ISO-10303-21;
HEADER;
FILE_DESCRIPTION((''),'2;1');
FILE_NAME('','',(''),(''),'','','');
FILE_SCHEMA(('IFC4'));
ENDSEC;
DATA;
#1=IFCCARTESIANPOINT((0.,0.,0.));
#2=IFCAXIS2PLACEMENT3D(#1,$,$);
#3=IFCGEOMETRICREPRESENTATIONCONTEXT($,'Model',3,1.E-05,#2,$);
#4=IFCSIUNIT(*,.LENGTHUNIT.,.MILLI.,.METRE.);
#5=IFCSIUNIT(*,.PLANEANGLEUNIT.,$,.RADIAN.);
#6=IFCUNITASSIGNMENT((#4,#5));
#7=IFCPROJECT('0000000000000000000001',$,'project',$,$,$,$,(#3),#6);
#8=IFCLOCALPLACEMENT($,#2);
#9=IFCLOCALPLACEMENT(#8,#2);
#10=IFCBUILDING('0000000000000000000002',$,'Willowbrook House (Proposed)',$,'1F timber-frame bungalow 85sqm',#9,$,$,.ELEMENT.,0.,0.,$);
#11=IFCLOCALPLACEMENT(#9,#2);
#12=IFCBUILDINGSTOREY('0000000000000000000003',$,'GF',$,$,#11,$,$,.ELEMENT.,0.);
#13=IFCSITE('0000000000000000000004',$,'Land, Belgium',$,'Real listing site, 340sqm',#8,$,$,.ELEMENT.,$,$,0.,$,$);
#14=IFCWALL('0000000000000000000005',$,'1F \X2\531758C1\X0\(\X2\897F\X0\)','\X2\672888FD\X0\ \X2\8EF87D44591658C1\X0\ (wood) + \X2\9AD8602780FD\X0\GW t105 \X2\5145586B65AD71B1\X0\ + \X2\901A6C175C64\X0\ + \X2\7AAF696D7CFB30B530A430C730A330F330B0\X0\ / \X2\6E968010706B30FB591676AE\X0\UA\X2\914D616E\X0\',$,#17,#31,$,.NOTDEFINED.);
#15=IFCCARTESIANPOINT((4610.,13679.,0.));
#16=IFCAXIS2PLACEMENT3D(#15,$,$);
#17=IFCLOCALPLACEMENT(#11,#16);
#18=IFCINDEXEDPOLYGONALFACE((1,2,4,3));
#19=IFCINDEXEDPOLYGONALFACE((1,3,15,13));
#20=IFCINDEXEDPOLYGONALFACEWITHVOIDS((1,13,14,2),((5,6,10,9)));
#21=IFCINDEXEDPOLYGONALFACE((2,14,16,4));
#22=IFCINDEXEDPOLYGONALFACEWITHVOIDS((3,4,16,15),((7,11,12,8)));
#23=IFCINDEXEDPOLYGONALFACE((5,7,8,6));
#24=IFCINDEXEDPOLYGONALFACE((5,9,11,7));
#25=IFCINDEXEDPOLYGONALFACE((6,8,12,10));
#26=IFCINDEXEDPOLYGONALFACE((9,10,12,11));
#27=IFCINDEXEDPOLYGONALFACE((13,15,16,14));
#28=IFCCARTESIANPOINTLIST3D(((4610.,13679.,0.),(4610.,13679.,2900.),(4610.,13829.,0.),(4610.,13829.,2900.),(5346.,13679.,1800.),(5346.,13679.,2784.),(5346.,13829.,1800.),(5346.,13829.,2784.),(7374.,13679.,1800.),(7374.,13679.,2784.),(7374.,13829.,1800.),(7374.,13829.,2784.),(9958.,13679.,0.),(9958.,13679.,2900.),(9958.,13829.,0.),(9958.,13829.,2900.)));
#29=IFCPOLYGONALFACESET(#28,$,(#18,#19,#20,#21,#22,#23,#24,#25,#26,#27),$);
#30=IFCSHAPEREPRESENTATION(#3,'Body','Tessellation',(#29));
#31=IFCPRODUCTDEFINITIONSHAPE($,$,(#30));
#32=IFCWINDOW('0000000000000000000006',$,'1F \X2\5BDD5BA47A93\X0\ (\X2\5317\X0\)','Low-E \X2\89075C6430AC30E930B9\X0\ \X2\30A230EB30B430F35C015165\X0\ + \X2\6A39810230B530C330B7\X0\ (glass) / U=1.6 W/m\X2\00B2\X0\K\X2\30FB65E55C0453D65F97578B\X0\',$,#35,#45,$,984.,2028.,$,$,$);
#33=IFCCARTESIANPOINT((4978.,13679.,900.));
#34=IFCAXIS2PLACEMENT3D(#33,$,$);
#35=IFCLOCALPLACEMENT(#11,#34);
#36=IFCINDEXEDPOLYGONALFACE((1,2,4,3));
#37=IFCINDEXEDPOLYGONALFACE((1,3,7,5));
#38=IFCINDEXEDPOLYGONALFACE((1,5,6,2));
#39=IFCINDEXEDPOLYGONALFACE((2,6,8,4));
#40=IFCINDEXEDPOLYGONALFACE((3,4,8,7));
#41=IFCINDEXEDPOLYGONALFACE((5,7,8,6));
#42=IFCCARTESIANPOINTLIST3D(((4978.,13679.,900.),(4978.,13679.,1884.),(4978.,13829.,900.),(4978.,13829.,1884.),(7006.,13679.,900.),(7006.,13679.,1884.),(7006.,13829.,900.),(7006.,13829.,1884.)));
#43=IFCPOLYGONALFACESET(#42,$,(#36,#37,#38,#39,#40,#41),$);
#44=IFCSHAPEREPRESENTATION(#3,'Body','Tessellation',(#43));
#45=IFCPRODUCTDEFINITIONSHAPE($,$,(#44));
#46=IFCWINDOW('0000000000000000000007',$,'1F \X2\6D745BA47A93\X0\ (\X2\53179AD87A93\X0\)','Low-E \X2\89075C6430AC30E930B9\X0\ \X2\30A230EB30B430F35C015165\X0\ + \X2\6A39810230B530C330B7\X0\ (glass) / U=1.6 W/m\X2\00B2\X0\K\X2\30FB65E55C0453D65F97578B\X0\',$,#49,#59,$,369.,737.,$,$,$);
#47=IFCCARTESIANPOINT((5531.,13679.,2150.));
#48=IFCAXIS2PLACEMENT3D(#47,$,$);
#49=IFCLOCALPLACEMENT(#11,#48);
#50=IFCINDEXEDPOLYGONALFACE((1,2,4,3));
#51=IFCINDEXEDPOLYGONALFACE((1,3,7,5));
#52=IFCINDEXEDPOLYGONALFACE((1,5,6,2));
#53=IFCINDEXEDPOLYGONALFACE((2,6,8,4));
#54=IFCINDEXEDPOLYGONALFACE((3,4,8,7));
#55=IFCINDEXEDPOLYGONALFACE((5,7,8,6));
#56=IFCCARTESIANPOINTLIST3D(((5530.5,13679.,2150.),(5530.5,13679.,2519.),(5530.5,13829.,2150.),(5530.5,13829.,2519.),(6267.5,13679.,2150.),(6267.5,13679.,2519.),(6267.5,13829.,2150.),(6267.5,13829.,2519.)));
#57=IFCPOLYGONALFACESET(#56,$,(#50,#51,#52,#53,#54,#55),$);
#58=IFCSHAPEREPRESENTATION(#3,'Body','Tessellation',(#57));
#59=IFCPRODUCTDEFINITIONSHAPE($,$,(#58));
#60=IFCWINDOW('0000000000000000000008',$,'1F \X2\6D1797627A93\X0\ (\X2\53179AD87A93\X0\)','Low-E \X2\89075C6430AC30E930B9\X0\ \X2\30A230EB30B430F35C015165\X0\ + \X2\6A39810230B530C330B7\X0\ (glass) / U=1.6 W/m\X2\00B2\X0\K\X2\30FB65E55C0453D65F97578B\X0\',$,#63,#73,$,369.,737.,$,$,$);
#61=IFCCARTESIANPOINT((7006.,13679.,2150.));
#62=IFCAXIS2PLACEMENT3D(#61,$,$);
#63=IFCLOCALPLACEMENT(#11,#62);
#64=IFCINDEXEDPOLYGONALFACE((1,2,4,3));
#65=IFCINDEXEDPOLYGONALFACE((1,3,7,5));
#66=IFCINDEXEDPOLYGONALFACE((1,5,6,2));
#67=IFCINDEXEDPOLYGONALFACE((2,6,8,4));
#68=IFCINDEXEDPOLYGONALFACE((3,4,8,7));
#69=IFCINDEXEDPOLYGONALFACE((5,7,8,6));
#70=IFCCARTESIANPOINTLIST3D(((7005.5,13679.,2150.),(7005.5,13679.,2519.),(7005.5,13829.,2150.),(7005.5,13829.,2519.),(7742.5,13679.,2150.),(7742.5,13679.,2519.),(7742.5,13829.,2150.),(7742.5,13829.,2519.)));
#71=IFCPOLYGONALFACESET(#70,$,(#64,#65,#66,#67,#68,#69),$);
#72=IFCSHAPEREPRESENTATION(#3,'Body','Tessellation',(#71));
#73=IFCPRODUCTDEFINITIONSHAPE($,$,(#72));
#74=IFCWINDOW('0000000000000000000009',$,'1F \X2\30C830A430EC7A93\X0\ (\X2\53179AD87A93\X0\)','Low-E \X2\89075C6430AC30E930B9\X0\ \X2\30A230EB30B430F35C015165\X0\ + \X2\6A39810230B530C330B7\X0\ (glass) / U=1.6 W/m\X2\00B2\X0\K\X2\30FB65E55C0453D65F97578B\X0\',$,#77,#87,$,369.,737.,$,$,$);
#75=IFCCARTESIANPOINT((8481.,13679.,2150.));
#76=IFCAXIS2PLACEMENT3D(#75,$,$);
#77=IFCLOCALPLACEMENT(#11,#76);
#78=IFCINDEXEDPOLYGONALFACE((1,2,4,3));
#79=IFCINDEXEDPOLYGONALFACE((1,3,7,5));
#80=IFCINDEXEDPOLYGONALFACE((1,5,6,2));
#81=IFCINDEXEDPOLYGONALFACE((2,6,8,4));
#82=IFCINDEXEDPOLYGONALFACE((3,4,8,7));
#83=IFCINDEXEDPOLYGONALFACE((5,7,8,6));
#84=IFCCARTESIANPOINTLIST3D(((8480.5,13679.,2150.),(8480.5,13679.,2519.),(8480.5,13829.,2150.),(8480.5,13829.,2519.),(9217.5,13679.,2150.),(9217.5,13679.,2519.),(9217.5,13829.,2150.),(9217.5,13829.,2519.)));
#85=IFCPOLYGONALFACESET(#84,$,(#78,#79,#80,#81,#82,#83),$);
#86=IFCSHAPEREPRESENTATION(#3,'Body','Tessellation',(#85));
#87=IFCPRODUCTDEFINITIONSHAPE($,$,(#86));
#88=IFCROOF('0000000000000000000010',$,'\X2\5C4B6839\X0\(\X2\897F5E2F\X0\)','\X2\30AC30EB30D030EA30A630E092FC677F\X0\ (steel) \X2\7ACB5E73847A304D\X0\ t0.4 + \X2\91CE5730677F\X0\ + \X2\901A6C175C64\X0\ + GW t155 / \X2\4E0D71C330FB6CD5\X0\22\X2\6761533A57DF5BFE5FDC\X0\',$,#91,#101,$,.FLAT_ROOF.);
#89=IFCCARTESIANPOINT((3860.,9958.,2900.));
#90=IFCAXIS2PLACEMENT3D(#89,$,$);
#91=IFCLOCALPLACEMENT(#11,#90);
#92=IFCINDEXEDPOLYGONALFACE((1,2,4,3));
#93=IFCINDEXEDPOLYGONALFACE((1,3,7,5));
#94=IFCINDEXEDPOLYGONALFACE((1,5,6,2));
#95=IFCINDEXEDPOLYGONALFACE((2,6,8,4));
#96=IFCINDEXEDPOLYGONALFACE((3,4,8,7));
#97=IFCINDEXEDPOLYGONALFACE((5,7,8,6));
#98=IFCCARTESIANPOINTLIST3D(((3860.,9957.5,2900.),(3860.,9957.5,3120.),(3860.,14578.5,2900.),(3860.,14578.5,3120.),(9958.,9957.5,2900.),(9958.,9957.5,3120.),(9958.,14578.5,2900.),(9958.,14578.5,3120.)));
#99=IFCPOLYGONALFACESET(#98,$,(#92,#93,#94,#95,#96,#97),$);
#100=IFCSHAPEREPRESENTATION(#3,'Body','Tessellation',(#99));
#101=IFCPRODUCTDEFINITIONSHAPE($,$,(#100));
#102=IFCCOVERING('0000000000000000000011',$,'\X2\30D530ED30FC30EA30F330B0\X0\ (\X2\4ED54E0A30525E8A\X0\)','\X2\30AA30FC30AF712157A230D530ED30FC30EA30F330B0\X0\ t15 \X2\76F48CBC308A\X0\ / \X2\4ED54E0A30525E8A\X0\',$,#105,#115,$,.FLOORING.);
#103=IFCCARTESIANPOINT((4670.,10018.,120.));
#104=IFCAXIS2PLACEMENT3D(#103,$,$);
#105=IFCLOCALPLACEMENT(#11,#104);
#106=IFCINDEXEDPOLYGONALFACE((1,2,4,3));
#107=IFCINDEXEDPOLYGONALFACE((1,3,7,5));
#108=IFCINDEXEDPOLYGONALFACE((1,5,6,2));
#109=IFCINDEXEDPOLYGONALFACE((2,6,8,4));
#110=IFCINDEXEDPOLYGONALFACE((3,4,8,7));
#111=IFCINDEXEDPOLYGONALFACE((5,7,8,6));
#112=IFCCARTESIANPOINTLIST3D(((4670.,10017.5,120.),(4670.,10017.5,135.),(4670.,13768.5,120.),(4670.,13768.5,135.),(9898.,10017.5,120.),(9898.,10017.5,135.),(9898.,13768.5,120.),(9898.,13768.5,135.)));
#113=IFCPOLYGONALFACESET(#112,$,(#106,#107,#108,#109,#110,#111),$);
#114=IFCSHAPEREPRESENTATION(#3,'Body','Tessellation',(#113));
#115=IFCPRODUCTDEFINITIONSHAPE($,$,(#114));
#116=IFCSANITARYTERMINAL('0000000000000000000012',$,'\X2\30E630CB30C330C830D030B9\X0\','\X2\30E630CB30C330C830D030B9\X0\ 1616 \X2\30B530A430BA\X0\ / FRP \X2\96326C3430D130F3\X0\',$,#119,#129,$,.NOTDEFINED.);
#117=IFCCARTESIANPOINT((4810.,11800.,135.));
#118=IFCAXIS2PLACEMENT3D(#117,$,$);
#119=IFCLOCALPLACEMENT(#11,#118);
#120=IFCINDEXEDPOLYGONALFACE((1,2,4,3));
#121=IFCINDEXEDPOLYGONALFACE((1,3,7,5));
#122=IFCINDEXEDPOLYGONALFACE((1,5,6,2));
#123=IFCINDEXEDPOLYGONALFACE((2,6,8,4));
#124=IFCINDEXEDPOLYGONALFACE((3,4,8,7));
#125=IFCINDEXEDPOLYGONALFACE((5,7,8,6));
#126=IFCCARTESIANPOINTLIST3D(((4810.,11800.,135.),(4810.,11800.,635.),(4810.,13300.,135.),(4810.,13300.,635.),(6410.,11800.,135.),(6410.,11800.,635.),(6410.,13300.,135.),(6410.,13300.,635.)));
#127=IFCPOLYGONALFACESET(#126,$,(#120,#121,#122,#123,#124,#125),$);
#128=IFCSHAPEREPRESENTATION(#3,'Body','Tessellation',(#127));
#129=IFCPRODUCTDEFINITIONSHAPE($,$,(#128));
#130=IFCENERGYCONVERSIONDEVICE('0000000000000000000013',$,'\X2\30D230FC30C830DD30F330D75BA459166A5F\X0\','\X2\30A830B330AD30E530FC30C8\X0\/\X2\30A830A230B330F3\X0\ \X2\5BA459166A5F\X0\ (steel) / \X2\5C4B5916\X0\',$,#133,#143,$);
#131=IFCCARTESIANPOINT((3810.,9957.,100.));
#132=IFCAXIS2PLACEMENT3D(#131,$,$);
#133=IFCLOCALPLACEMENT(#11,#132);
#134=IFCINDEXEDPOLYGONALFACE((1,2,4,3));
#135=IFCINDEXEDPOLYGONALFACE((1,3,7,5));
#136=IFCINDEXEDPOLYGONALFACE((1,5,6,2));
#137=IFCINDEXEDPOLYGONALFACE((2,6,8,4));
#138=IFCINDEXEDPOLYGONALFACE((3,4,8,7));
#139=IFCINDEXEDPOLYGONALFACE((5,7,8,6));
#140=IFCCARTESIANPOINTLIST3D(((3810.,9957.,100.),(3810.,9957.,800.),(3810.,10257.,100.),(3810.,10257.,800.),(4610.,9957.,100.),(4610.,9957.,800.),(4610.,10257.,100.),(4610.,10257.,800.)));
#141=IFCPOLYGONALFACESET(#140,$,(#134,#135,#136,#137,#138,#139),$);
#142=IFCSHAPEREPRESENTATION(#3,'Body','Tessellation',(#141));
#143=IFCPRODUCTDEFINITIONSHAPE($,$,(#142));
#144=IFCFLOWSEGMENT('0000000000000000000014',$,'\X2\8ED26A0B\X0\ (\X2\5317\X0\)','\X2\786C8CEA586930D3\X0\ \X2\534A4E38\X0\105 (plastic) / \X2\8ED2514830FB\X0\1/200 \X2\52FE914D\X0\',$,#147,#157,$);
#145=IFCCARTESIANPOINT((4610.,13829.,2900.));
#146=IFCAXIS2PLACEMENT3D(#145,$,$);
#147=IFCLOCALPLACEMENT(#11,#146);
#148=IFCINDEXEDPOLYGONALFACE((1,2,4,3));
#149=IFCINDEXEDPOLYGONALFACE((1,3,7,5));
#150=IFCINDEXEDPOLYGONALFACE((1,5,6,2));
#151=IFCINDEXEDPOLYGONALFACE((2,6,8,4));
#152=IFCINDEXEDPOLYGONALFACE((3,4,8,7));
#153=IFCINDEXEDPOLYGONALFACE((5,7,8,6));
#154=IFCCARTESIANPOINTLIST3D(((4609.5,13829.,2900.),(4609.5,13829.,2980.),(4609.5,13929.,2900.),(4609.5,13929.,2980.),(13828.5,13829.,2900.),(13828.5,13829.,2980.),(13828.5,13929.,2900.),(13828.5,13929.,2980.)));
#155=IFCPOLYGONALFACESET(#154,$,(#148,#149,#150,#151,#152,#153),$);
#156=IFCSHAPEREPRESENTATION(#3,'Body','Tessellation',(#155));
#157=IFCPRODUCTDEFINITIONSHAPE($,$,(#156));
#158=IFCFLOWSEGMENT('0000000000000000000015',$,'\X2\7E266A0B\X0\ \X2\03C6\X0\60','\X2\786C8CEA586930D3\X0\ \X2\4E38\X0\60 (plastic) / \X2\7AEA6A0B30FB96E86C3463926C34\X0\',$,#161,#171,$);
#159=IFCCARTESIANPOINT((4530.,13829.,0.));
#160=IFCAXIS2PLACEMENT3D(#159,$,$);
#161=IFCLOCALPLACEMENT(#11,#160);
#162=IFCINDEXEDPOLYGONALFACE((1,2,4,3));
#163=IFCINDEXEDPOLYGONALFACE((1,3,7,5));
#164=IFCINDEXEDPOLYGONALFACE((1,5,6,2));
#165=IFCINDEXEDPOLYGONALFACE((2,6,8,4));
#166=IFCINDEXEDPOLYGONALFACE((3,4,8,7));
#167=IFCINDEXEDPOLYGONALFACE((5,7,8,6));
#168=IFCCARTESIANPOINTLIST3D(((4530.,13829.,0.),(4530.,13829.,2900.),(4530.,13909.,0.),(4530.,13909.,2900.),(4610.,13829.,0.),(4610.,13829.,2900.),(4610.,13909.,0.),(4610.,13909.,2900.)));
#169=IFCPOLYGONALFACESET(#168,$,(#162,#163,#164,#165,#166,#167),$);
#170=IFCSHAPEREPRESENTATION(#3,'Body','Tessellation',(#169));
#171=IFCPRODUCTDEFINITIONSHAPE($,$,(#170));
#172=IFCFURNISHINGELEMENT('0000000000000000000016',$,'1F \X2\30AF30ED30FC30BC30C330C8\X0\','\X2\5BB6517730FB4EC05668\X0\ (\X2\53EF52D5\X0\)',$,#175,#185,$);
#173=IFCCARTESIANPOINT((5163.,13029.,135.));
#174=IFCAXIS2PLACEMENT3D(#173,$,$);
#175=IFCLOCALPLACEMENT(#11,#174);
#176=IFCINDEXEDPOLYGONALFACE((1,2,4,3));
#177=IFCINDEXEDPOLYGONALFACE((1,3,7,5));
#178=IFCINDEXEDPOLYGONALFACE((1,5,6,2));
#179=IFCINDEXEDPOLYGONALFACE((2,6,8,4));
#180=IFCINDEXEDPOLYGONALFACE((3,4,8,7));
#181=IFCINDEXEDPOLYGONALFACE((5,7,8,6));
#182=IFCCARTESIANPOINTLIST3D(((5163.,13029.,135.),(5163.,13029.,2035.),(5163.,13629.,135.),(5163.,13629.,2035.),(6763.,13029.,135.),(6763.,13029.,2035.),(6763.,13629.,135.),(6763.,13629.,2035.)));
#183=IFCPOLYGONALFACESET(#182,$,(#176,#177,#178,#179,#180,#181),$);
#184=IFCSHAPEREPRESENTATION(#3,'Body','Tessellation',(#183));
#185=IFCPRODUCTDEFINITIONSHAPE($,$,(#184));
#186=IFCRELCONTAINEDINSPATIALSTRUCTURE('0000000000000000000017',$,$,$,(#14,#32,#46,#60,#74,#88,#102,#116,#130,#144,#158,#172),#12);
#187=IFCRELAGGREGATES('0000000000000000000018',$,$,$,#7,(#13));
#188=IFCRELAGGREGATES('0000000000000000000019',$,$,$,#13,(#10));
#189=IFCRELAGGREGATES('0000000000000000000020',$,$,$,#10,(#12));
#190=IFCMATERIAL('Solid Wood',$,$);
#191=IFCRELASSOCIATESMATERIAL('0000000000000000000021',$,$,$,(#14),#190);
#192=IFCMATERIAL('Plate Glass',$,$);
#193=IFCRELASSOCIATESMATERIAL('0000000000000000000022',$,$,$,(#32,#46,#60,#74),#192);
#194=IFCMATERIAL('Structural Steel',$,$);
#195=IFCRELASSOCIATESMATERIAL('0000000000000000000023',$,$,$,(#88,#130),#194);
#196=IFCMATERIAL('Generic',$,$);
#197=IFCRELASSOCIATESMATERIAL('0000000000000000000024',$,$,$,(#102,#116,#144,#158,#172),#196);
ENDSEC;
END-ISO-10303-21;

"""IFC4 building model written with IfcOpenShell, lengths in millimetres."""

from ifc_helpers import new_model, si_unit, frame, frame_2d, origin, place, context, project, spatial, rectangle, extrude, material, element, fill, save


model = new_model("IFC4")

# Units and contexts
model_context = context("Model", 3, precision=1e-05, world=origin())
ifc_project = project(units=[si_unit("LENGTHUNIT", "METRE", prefix="MILLI"), si_unit("PLANEANGLEUNIT", "RADIAN")], contexts=[model_context])

# Site, building, storey
site_placement = place(None, origin())
site = spatial("IfcSite", under=ifc_project, at=site_placement, Name="Land, Belgium", ObjectType="Real listing site, 340sqm", CompositionType="ELEMENT", RefElevation=0.0)
building_placement = place(site_placement, origin())
building = spatial("IfcBuilding", under=site, at=building_placement, Name="Willowbrook House (Proposed)", ObjectType="1F timber-frame bungalow 85sqm", CompositionType="ELEMENT", ElevationOfRefHeight=0.0, ElevationOfTerrain=0.0)
storey_placement = place(building_placement, origin())
storey = spatial("IfcBuildingStorey", under=building, at=storey_placement, Name="GF", CompositionType="ELEMENT", Elevation=0.0)

# Shared definitions
ifc_material_1 = material(Name="Solid Wood")

# Wall, openings, windows
wall_1_placement = place(storey_placement, frame((4610.0, 13679.0, 0.0)))
wall_1 = element("IfcWall", 1, at=wall_1_placement, inside=storey, material=ifc_material_1, Name="1F 北壁(西)", Description="木製 軸組外壁 (wood) + 高性能GW t105 充填断熱 + 通気層 + 窯業系サイディング / 準耐火・外皮UA配慮", PredefinedType="NOTDEFINED", context=model_context, shape_type="SweptSolid", body=[
    extrude(rectangle(XDim=5348.0, YDim=150.0, at=frame_2d((2674.0, 75.0))), frame((4610.0, 13679.0, 0.0)), (0.0, 0.0, 1.0), 2900.0),
])
opening_1_placement = place(storey_placement, frame((4978.0, 13679.0, 900.0)))
opening_1 = element("IfcOpeningElement", 2, at=opening_1_placement, cuts=wall_1, PredefinedType="NOTDEFINED", context=model_context, shape_type="SweptSolid", body=[
    extrude(rectangle(XDim=2028.0, YDim=150.0, at=frame_2d((1014.0, 75.0))), frame((4978.0, 13679.0, 900.0)), (0.0, 0.0, 1.0), 984.0),
])
opening_2_placement = place(storey_placement, frame((5531.0, 13679.0, 2150.0)))
opening_2 = element("IfcOpeningElement", 3, at=opening_2_placement, cuts=wall_1, PredefinedType="NOTDEFINED", context=model_context, shape_type="SweptSolid", body=[
    extrude(rectangle(XDim=737.0, YDim=150.0, at=frame_2d((368.0, 75.0))), frame((5531.0, 13679.0, 2150.0)), (0.0, 0.0, 1.0), 369.0),
])
opening_3_placement = place(storey_placement, frame((7006.0, 13679.0, 2150.0)))
opening_3 = element("IfcOpeningElement", 4, at=opening_3_placement, cuts=wall_1, PredefinedType="NOTDEFINED", context=model_context, shape_type="SweptSolid", body=[
    extrude(rectangle(XDim=737.0, YDim=150.0, at=frame_2d((368.0, 75.0))), frame((7006.0, 13679.0, 2150.0)), (0.0, 0.0, 1.0), 369.0),
])
opening_4_placement = place(storey_placement, frame((8481.0, 13679.0, 2150.0)))
opening_4 = element("IfcOpeningElement", 5, at=opening_4_placement, cuts=wall_1, PredefinedType="NOTDEFINED", context=model_context, shape_type="SweptSolid", body=[
    extrude(rectangle(XDim=737.0, YDim=150.0, at=frame_2d((368.0, 75.0))), frame((8481.0, 13679.0, 2150.0)), (0.0, 0.0, 1.0), 369.0),
])
ifc_material_2 = material(Name="Plate Glass")
window_1_placement = place(storey_placement, frame((4978.0, 13679.0, 900.0)))
window_1 = element("IfcWindow", 6, at=window_1_placement, inside=storey, material=ifc_material_2, Name="1F 寝室窓 (北)", Description="Low-E 複層ガラス アルゴン封入 + 樹脂サッシ (glass) / U=1.6 W/m²K・日射取得型", OverallHeight=984.0, OverallWidth=2028.0, context=model_context, shape_type="SweptSolid", body=[
    extrude(rectangle(XDim=2028.0, YDim=150.0, at=frame_2d((1014.0, 75.0))), frame((4978.0, 13679.0, 900.0)), (0.0, 0.0, 1.0), 984.0),
])
fill(opening_1, window_1)
window_2_placement = place(storey_placement, frame((5531.0, 13679.0, 2150.0)))
window_2 = element("IfcWindow", 7, at=window_2_placement, inside=storey, material=ifc_material_2, Name="1F 浴室窓 (北高窓)", Description="Low-E 複層ガラス アルゴン封入 + 樹脂サッシ (glass) / U=1.6 W/m²K・日射取得型", OverallHeight=369.0, OverallWidth=737.0, context=model_context, shape_type="SweptSolid", body=[
    extrude(rectangle(XDim=737.0, YDim=150.0, at=frame_2d((368.0, 75.0))), frame((5531.0, 13679.0, 2150.0)), (0.0, 0.0, 1.0), 369.0),
])
fill(opening_2, window_2)
window_3_placement = place(storey_placement, frame((7006.0, 13679.0, 2150.0)))
window_3 = element("IfcWindow", 8, at=window_3_placement, inside=storey, material=ifc_material_2, Name="1F 洗面窓 (北高窓)", Description="Low-E 複層ガラス アルゴン封入 + 樹脂サッシ (glass) / U=1.6 W/m²K・日射取得型", OverallHeight=369.0, OverallWidth=737.0, context=model_context, shape_type="SweptSolid", body=[
    extrude(rectangle(XDim=737.0, YDim=150.0, at=frame_2d((368.0, 75.0))), frame((7006.0, 13679.0, 2150.0)), (0.0, 0.0, 1.0), 369.0),
])
fill(opening_3, window_3)
window_4_placement = place(storey_placement, frame((8481.0, 13679.0, 2150.0)))
window_4 = element("IfcWindow", 9, at=window_4_placement, inside=storey, material=ifc_material_2, Name="1F トイレ窓 (北高窓)", Description="Low-E 複層ガラス アルゴン封入 + 樹脂サッシ (glass) / U=1.6 W/m²K・日射取得型", OverallHeight=369.0, OverallWidth=737.0, context=model_context, shape_type="SweptSolid", body=[
    extrude(rectangle(XDim=737.0, YDim=150.0, at=frame_2d((368.0, 75.0))), frame((8481.0, 13679.0, 2150.0)), (0.0, 0.0, 1.0), 369.0),
])
fill(opening_4, window_4)

# Roof
ifc_material_3 = material(Name="Structural Steel")
roof_placement = place(storey_placement, frame((3860.0, 9958.0, 2900.0)))
element("IfcRoof", 10, at=roof_placement, inside=storey, material=ifc_material_3, Name="屋根(西帯)", Description="ガルバリウム鋼板 (steel) 立平葺き t0.4 + 野地板 + 通気層 + GW t155 / 不燃・法22条区域対応", PredefinedType="FLAT_ROOF", context=model_context, shape_type="SweptSolid", body=[
    extrude(rectangle(XDim=6098.0, YDim=4621.0, at=frame_2d((3049.0, 2310.0))), frame((3860.0, 9958.0, 2900.0)), (0.0, 0.0, 1.0), 220.0),
])

# Covering
ifc_material_4 = material(Name="Generic")
covering_placement = place(storey_placement, frame((4670.0, 10018.0, 120.0)))
element("IfcCovering", 11, at=covering_placement, inside=storey, material=ifc_material_4, Name="フローリング (仕上げ床)", Description="オーク無垢フローリング t15 直貼り / 仕上げ床", PredefinedType="FLOORING", context=model_context, shape_type="SweptSolid", body=[
    extrude(rectangle(XDim=5228.0, YDim=3751.0, at=frame_2d((2614.0, 1875.0))), frame((4670.0, 10018.0, 120.0)), (0.0, 0.0, 1.0), 15.0),
])

# Sanitary terminal
sanitary_terminal_placement = place(storey_placement, frame((4810.0, 11800.0, 135.0)))
element("IfcSanitaryTerminal", 12, at=sanitary_terminal_placement, inside=storey, material=ifc_material_4, Name="ユニットバス", Description="ユニットバス 1616 サイズ / FRP 防水パン", PredefinedType="NOTDEFINED", context=model_context, shape_type="SweptSolid", body=[
    extrude(rectangle(XDim=1600.0, YDim=1500.0, at=frame_2d((800.0, 750.0))), frame((4810.0, 11800.0, 135.0)), (0.0, 0.0, 1.0), 500.0),
])

# Energy conversion device
energy_conversion_device_placement = place(storey_placement, frame((3810.0, 9957.0, 100.0)))
element("IfcEnergyConversionDevice", 13, at=energy_conversion_device_placement, inside=storey, material=ifc_material_3, Name="ヒートポンプ室外機", Description="エコキュート/エアコン 室外機 (steel) / 屋外", context=model_context, shape_type="SweptSolid", body=[
    extrude(rectangle(XDim=800.0, YDim=300.0, at=frame_2d((400.0, 150.0))), frame((3810.0, 9957.0, 100.0)), (0.0, 0.0, 1.0), 700.0),
])

# Flow segments
flow_segment_1_placement = place(storey_placement, frame((4610.0, 13829.0, 2900.0)))
element("IfcFlowSegment", 14, at=flow_segment_1_placement, inside=storey, material=ifc_material_4, Name="軒樋 (北)", Description="硬質塩ビ 半丸105 (plastic) / 軒先・1/200 勾配", context=model_context, shape_type="SweptSolid", body=[
    extrude(rectangle(XDim=9219.0, YDim=100.0, at=frame_2d((4609.0, 50.0))), frame((4610.0, 13829.0, 2900.0)), (0.0, 0.0, 1.0), 80.0),
])
flow_segment_2_placement = place(storey_placement, frame((4530.0, 13829.0, 0.0)))
element("IfcFlowSegment", 15, at=flow_segment_2_placement, inside=storey, material=ifc_material_4, Name="縦樋 φ60", Description="硬質塩ビ 丸60 (plastic) / 竪樋・雨水排水", context=model_context, shape_type="SweptSolid", body=[
    extrude(rectangle(XDim=80.0, YDim=80.0, at=frame_2d((40.0, 40.0))), frame((4530.0, 13829.0, 0.0)), (0.0, 0.0, 1.0), 2900.0),
])

# Furnishing element
furnishing_1_placement = place(storey_placement, frame((5163.0, 13029.0, 135.0)))
element("IfcFurnishingElement", 16, at=furnishing_1_placement, inside=storey, material=ifc_material_4, Name="1F クローゼット", Description="家具・什器 (可動)", context=model_context, shape_type="SweptSolid", body=[
    extrude(rectangle(XDim=1600.0, YDim=600.0, at=frame_2d((800.0, 300.0))), frame((5163.0, 13029.0, 135.0)), (0.0, 0.0, 1.0), 1900.0),
])

save(model, "model.ifc")
